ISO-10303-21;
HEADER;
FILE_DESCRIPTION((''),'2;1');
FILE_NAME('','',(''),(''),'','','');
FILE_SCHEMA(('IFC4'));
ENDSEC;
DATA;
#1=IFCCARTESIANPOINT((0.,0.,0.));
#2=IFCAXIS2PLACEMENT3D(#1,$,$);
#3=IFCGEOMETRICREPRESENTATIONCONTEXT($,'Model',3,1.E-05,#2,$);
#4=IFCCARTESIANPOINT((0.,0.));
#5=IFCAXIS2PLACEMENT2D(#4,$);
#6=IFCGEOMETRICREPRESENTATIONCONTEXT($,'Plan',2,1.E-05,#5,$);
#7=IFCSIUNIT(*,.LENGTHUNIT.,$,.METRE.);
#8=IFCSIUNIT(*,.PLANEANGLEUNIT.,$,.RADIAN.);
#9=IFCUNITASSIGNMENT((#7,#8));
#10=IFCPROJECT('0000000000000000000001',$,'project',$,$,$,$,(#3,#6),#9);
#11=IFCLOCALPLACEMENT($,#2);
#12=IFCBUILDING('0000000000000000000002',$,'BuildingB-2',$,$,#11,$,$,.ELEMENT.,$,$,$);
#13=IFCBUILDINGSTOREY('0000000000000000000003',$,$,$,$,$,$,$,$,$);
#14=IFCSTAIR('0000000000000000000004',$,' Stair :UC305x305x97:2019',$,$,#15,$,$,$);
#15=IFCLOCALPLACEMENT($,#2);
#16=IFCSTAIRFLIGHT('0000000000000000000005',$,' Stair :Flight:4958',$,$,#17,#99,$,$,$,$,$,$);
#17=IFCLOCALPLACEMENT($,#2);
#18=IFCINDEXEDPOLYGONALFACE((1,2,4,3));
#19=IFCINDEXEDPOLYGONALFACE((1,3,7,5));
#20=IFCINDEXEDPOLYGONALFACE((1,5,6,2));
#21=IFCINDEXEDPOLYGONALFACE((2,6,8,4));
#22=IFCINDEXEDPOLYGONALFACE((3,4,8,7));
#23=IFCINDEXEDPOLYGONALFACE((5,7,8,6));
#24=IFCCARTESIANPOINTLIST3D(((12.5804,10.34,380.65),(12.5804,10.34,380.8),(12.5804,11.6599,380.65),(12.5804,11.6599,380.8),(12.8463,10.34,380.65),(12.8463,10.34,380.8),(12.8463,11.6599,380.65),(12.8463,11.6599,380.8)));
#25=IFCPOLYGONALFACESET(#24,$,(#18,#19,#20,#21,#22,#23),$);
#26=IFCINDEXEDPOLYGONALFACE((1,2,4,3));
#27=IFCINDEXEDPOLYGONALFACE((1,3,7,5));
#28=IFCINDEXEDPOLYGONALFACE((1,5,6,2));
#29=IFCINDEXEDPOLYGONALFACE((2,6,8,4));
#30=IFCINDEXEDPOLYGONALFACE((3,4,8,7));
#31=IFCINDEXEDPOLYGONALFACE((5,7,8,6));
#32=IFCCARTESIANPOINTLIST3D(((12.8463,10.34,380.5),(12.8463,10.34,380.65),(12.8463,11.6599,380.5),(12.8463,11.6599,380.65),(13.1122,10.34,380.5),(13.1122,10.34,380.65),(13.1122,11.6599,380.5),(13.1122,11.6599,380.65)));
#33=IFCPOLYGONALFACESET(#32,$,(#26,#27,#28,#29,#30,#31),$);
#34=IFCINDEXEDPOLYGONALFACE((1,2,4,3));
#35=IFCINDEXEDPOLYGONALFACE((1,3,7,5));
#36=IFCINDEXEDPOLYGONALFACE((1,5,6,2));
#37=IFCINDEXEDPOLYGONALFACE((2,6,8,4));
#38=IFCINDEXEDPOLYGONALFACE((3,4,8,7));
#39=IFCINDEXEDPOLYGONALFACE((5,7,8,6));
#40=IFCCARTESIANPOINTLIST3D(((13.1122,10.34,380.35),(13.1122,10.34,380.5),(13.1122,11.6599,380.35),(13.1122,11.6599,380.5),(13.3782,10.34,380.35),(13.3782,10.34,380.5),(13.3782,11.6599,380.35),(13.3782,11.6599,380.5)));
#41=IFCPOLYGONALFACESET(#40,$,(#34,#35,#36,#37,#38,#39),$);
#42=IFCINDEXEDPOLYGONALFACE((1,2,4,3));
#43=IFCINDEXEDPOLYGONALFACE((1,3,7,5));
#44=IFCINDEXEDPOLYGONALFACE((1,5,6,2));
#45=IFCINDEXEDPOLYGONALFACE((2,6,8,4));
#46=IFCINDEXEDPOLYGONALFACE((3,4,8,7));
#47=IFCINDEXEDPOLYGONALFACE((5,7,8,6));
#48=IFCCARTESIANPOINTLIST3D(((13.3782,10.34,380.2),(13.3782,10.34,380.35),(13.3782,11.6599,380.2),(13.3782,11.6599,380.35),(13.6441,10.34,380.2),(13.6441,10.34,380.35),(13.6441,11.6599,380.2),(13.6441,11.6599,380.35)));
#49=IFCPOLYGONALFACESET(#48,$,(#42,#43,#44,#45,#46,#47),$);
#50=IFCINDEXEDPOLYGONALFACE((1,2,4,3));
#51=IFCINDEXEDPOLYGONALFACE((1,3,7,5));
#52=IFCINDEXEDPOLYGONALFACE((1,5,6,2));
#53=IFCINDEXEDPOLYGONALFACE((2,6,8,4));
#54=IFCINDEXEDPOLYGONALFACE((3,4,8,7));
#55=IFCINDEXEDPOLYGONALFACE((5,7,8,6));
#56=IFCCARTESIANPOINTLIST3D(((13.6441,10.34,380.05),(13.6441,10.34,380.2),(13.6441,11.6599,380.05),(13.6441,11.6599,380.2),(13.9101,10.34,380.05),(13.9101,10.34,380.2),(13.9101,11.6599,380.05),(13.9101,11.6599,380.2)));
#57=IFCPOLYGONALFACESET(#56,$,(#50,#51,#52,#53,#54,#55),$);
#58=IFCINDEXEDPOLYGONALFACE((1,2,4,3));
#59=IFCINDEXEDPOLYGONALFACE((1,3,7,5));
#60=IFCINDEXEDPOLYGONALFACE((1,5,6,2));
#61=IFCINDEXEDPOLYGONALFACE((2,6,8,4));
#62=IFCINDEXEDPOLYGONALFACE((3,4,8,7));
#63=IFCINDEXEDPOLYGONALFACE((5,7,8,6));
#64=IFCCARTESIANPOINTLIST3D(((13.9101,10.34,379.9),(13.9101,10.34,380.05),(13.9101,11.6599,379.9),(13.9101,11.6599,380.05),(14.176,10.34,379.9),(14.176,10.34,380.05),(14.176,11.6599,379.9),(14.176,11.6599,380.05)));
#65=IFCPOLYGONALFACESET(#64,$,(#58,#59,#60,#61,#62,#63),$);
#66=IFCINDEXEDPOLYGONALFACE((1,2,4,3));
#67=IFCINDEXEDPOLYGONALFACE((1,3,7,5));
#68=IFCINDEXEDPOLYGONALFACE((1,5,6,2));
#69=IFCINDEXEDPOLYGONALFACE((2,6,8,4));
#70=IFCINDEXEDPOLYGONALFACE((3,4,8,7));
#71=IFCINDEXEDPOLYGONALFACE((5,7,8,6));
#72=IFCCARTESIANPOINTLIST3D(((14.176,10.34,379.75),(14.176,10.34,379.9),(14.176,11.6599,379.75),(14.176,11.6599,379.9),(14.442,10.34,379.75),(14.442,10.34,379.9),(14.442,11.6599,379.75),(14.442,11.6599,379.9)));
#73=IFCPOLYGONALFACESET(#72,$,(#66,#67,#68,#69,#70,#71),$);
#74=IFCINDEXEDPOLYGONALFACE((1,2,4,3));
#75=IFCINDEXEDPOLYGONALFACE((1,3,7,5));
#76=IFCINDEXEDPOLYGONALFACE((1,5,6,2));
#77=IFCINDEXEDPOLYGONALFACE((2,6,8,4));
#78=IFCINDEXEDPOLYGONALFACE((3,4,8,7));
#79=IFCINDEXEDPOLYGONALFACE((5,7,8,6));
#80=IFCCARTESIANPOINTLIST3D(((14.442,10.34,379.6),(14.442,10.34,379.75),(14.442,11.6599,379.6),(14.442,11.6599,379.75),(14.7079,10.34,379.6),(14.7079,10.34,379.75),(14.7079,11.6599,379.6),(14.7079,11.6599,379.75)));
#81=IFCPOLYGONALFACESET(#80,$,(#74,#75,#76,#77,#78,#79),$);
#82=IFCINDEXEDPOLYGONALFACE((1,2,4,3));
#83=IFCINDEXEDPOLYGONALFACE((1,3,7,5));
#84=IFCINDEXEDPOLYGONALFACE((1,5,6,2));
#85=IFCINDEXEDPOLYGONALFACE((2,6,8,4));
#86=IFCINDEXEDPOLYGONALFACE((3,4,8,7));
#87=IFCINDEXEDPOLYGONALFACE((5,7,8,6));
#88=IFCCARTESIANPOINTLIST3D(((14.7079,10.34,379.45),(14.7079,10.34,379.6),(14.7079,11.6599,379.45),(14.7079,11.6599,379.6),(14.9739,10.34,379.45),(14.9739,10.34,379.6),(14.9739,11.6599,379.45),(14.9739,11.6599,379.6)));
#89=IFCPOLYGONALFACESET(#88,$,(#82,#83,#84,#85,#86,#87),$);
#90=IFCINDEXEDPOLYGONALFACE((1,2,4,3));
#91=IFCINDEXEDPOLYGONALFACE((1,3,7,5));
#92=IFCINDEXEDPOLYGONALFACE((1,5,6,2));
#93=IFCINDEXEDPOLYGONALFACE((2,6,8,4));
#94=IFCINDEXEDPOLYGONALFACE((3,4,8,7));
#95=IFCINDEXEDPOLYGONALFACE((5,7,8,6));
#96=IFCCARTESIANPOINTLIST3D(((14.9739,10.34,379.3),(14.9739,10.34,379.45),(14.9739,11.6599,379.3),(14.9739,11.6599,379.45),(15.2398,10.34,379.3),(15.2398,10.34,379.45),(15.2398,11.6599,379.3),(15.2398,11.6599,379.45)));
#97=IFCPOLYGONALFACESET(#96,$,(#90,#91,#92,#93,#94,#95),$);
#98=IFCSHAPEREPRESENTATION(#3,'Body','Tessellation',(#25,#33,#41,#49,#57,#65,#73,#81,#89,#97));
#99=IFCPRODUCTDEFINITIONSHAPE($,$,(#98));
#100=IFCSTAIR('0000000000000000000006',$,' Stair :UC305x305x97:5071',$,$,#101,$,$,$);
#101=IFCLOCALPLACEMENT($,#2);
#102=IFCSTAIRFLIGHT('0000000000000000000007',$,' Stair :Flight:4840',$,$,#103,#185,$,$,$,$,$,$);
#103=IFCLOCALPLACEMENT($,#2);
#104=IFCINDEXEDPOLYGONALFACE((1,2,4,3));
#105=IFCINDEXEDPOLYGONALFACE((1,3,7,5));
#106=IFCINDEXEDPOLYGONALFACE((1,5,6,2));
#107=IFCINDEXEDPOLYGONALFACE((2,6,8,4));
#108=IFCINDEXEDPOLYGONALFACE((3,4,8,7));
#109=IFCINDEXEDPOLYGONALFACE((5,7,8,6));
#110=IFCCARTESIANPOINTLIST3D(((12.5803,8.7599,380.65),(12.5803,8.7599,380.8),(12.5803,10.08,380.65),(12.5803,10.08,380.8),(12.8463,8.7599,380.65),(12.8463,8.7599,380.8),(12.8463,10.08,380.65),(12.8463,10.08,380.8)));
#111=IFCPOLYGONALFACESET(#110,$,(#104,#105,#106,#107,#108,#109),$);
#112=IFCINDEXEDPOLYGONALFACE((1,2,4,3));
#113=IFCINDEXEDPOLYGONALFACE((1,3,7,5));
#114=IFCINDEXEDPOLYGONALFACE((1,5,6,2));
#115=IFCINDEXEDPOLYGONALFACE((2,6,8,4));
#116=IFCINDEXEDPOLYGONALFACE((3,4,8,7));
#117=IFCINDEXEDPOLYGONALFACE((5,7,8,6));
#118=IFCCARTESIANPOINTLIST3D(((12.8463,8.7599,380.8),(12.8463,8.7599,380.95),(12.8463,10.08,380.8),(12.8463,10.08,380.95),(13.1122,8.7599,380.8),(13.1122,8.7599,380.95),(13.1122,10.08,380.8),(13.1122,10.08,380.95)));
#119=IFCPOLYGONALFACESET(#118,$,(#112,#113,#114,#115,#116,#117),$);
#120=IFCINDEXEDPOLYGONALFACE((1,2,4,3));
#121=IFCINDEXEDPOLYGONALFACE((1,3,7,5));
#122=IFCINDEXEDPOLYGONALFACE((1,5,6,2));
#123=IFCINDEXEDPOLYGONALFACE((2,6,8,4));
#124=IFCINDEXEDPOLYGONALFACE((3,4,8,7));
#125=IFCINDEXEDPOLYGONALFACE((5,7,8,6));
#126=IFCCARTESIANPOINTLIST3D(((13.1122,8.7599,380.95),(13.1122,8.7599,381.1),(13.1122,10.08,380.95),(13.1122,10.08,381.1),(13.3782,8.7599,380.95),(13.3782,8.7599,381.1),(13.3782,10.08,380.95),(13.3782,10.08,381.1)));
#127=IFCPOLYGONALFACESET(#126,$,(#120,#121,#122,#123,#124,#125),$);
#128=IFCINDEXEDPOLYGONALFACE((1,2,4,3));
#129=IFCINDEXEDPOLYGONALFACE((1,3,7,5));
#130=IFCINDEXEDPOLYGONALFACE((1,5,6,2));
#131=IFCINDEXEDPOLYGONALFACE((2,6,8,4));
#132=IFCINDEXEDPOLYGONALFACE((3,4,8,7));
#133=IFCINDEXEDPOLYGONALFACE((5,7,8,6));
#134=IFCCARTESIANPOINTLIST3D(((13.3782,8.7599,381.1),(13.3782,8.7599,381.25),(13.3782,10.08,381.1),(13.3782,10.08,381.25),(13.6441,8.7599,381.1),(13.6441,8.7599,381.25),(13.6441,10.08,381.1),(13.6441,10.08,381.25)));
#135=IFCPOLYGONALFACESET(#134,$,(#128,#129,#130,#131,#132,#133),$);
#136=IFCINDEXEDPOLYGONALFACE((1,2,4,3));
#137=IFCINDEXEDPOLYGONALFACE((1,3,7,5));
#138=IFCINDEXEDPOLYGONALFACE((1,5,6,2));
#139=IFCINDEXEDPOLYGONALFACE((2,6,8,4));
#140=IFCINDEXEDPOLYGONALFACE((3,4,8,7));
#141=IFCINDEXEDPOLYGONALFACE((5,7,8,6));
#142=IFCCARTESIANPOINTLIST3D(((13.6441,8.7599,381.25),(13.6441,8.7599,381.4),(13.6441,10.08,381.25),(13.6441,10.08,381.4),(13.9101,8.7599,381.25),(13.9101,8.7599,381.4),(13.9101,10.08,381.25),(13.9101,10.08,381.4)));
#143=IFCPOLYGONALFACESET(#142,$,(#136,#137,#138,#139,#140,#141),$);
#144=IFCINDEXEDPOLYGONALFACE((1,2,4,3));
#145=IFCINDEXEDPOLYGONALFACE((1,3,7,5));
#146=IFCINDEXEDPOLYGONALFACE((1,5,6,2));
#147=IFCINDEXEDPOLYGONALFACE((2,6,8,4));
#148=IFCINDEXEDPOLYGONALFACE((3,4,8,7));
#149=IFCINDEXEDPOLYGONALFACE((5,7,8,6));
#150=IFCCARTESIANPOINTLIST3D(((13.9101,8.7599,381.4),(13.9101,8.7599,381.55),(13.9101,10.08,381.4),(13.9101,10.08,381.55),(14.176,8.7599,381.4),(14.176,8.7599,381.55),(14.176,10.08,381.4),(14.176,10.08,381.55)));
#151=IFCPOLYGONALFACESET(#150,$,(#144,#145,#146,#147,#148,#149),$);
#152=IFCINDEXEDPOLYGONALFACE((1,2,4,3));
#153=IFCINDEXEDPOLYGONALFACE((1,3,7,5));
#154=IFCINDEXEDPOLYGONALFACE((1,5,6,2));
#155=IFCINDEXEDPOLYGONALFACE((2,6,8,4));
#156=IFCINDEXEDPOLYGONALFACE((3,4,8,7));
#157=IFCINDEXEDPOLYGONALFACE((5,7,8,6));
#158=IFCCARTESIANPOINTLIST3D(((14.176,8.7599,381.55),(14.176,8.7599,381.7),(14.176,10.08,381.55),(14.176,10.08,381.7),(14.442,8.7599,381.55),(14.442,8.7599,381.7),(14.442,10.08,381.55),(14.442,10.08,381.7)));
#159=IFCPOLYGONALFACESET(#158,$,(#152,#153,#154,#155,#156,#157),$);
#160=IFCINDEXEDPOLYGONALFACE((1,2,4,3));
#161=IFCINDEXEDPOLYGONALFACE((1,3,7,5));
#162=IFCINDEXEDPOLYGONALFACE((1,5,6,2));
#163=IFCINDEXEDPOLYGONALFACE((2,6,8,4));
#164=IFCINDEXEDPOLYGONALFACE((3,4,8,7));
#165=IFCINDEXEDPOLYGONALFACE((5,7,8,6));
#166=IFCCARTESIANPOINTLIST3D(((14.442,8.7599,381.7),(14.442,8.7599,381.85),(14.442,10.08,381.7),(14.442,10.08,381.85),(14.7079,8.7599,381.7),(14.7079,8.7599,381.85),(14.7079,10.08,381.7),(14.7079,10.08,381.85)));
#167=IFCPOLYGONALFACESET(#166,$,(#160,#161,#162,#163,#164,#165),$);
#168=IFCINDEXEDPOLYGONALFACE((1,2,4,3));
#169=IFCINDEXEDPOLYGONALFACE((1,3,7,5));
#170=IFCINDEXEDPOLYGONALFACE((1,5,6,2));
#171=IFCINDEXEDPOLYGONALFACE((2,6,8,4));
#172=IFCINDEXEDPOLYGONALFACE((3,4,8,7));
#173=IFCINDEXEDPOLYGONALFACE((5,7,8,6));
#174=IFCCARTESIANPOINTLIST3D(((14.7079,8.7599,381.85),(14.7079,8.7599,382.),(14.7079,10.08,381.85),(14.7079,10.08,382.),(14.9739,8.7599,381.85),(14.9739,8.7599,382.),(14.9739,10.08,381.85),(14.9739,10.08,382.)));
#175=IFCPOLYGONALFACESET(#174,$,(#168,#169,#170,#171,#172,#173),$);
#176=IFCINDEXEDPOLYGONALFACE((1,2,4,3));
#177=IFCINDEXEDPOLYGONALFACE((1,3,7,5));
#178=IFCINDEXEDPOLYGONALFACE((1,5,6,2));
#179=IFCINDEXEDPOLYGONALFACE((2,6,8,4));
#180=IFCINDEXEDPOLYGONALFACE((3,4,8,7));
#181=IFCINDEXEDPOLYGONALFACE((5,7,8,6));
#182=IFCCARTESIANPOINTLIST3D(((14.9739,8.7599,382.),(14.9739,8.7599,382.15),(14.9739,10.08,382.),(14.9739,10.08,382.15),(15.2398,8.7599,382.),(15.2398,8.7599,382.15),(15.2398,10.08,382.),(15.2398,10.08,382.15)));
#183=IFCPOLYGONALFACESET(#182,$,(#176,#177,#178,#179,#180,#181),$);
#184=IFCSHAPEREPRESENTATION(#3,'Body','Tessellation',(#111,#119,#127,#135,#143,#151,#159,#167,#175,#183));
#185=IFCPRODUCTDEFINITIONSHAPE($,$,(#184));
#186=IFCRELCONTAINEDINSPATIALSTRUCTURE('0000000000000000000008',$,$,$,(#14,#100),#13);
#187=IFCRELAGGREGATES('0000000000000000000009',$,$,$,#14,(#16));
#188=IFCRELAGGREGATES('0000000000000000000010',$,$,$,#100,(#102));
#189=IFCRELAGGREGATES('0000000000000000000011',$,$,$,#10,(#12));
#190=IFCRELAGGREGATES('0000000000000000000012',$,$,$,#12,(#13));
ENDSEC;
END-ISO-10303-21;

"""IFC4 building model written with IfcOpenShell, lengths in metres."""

from ifc_helpers import new_model, si_unit, frame, origin, origin_2d, place, context, project, spatial, polyline, outline, extrude, element, aggregate, save


model = new_model("IFC4")

# Units and contexts
model_context = context("Model", 3, precision=1e-05, world=origin())
plan_context = context("Plan", 2, precision=1e-05, world=origin_2d())
ifc_project = project(units=[si_unit("LENGTHUNIT", "METRE"), si_unit("PLANEANGLEUNIT", "RADIAN")], contexts=[model_context, plan_context])

# Building, storey
building_placement = place(None, origin())
building = spatial("IfcBuilding", under=ifc_project, at=building_placement, Name="BuildingB-2", CompositionType="ELEMENT")
storey = spatial("IfcBuildingStorey", under=building)

# Stairs, stair flights
stair_1 = element("IfcStair", 1, inside=storey, Name=" Stair :UC305x305x97:2019")
stair_flight_1 = element("IfcStairFlight", 2, Name=" Stair :Flight:4958", context=model_context, shape_type="SweptSolid", body=[
    extrude(outline(polyline([(12.8463, 11.6599, 380.8), (12.8463, 10.34, 380.8), (12.5804, 10.34, 380.8), (12.5804, 11.6599, 380.8), (12.8463, 11.6599, 380.8)])), origin(), (0.0, 0.0, -1.0), 0.15),
    extrude(outline(polyline([(13.1122, 11.6599, 380.8), (13.1122, 10.34, 380.8), (12.8463, 10.34, 380.8), (12.8463, 11.6599, 380.8), (13.1122, 11.6599, 380.8)])), frame((0.0, 0.0, -0.15)), (0.0, 0.0, -1.0), 0.15),
    extrude(outline(polyline([(13.3782, 11.6599, 380.8), (13.3782, 10.34, 380.8), (13.1122, 10.34, 380.8), (13.1122, 11.6599, 380.8), (13.3782, 11.6599, 380.8)])), frame((0.0, 0.0, -0.3)), (0.0, 0.0, -1.0), 0.15),
    extrude(outline(polyline([(13.6441, 11.6599, 380.8), (13.6441, 10.34, 380.8), (13.3782, 10.34, 380.8), (13.3782, 11.6599, 380.8), (13.6441, 11.6599, 380.8)])), frame((0.0, 0.0, -0.45)), (0.0, 0.0, -1.0), 0.15),
    extrude(outline(polyline([(13.9101, 11.6599, 380.8), (13.9101, 10.34, 380.8), (13.6441, 10.34, 380.8), (13.6441, 11.6599, 380.8), (13.9101, 11.6599, 380.8)])), frame((0.0, 0.0, -0.6)), (0.0, 0.0, -1.0), 0.15),
    extrude(outline(polyline([(14.176, 11.6599, 380.8), (14.176, 10.34, 380.8), (13.9101, 10.34, 380.8), (13.9101, 11.6599, 380.8), (14.176, 11.6599, 380.8)])), frame((0.0, 0.0, -0.75)), (0.0, 0.0, -1.0), 0.15),
    extrude(outline(polyline([(14.442, 11.6599, 380.8), (14.442, 10.34, 380.8), (14.176, 10.34, 380.8), (14.176, 11.6599, 380.8), (14.442, 11.6599, 380.8)])), frame((0.0, 0.0, -0.9)), (0.0, 0.0, -1.0), 0.15),
    extrude(outline(polyline([(14.7079, 11.6599, 380.8), (14.7079, 10.34, 380.8), (14.442, 10.34, 380.8), (14.442, 11.6599, 380.8), (14.7079, 11.6599, 380.8)])), frame((0.0, 0.0, -1.05)), (0.0, 0.0, -1.0), 0.15),
    extrude(outline(polyline([(14.9739, 11.6599, 380.8), (14.9739, 10.34, 380.8), (14.7079, 10.34, 380.8), (14.7079, 11.6599, 380.8), (14.9739, 11.6599, 380.8)])), frame((0.0, 0.0, -1.2)), (0.0, 0.0, -1.0), 0.15),
    extrude(outline(polyline([(15.2398, 11.6599, 380.8), (15.2398, 10.34, 380.8), (14.9739, 10.34, 380.8), (14.9739, 11.6599, 380.8), (15.2398, 11.6599, 380.8)])), frame((0.0, 0.0, -1.35)), (0.0, 0.0, -1.0), 0.15),
])
aggregate(stair_1, [stair_flight_1])
stair_2 = element("IfcStair", 3, inside=storey, Name=" Stair :UC305x305x97:5071")
stair_flight_2 = element("IfcStairFlight", 4, Name=" Stair :Flight:4840", context=model_context, shape_type="SweptSolid", body=[
    extrude(outline(polyline([(12.8463, 8.7599, 380.8), (12.8463, 10.08, 380.8), (12.5803, 10.08, 380.8), (12.5803, 8.7599, 380.8), (12.8463, 8.7599, 380.8)])), origin(), (0.0, 0.0, -1.0), 0.15),
    extrude(outline(polyline([(13.1122, 8.7599, 380.8), (13.1122, 10.08, 380.8), (12.8463, 10.08, 380.8), (12.8463, 8.7599, 380.8), (13.1122, 8.7599, 380.8)])), frame((0.0, 0.0, 0.15)), (0.0, 0.0, -1.0), 0.15),
    extrude(outline(polyline([(13.3782, 8.7599, 380.8), (13.3782, 10.08, 380.8), (13.1122, 10.08, 380.8), (13.1122, 8.7599, 380.8), (13.3782, 8.7599, 380.8)])), frame((0.0, 0.0, 0.3)), (0.0, 0.0, -1.0), 0.15),
    extrude(outline(polyline([(13.6441, 8.7599, 380.8), (13.6441, 10.08, 380.8), (13.3782, 10.08, 380.8), (13.3782, 8.7599, 380.8), (13.6441, 8.7599, 380.8)])), frame((0.0, 0.0, 0.45)), (0.0, 0.0, -1.0), 0.15),
    extrude(outline(polyline([(13.9101, 8.7599, 380.8), (13.9101, 10.08, 380.8), (13.6441, 10.08, 380.8), (13.6441, 8.7599, 380.8), (13.9101, 8.7599, 380.8)])), frame((0.0, 0.0, 0.6)), (0.0, 0.0, -1.0), 0.15),
    extrude(outline(polyline([(14.176, 8.7599, 380.8), (14.176, 10.08, 380.8), (13.9101, 10.08, 380.8), (13.9101, 8.7599, 380.8), (14.176, 8.7599, 380.8)])), frame((0.0, 0.0, 0.75)), (0.0, 0.0, -1.0), 0.15),
    extrude(outline(polyline([(14.442, 8.7599, 380.8), (14.442, 10.08, 380.8), (14.176, 10.08, 380.8), (14.176, 8.7599, 380.8), (14.442, 8.7599, 380.8)])), frame((0.0, 0.0, 0.9)), (0.0, 0.0, -1.0), 0.15),
    extrude(outline(polyline([(14.7079, 8.7599, 380.8), (14.7079, 10.08, 380.8), (14.442, 10.08, 380.8), (14.442, 8.7599, 380.8), (14.7079, 8.7599, 380.8)])), frame((0.0, 0.0, 1.05)), (0.0, 0.0, -1.0), 0.15),
    extrude(outline(polyline([(14.9739, 8.7599, 380.8), (14.9739, 10.08, 380.8), (14.7079, 10.08, 380.8), (14.7079, 8.7599, 380.8), (14.9739, 8.7599, 380.8)])), frame((0.0, 0.0, 1.2)), (0.0, 0.0, -1.0), 0.15),
    extrude(outline(polyline([(15.2398, 8.7599, 380.8), (15.2398, 10.08, 380.8), (14.9739, 10.08, 380.8), (14.9739, 8.7599, 380.8), (15.2398, 8.7599, 380.8)])), frame((0.0, 0.0, 1.35)), (0.0, 0.0, -1.0), 0.15),
])
aggregate(stair_2, [stair_flight_2])

save(model, "model.ifc")
